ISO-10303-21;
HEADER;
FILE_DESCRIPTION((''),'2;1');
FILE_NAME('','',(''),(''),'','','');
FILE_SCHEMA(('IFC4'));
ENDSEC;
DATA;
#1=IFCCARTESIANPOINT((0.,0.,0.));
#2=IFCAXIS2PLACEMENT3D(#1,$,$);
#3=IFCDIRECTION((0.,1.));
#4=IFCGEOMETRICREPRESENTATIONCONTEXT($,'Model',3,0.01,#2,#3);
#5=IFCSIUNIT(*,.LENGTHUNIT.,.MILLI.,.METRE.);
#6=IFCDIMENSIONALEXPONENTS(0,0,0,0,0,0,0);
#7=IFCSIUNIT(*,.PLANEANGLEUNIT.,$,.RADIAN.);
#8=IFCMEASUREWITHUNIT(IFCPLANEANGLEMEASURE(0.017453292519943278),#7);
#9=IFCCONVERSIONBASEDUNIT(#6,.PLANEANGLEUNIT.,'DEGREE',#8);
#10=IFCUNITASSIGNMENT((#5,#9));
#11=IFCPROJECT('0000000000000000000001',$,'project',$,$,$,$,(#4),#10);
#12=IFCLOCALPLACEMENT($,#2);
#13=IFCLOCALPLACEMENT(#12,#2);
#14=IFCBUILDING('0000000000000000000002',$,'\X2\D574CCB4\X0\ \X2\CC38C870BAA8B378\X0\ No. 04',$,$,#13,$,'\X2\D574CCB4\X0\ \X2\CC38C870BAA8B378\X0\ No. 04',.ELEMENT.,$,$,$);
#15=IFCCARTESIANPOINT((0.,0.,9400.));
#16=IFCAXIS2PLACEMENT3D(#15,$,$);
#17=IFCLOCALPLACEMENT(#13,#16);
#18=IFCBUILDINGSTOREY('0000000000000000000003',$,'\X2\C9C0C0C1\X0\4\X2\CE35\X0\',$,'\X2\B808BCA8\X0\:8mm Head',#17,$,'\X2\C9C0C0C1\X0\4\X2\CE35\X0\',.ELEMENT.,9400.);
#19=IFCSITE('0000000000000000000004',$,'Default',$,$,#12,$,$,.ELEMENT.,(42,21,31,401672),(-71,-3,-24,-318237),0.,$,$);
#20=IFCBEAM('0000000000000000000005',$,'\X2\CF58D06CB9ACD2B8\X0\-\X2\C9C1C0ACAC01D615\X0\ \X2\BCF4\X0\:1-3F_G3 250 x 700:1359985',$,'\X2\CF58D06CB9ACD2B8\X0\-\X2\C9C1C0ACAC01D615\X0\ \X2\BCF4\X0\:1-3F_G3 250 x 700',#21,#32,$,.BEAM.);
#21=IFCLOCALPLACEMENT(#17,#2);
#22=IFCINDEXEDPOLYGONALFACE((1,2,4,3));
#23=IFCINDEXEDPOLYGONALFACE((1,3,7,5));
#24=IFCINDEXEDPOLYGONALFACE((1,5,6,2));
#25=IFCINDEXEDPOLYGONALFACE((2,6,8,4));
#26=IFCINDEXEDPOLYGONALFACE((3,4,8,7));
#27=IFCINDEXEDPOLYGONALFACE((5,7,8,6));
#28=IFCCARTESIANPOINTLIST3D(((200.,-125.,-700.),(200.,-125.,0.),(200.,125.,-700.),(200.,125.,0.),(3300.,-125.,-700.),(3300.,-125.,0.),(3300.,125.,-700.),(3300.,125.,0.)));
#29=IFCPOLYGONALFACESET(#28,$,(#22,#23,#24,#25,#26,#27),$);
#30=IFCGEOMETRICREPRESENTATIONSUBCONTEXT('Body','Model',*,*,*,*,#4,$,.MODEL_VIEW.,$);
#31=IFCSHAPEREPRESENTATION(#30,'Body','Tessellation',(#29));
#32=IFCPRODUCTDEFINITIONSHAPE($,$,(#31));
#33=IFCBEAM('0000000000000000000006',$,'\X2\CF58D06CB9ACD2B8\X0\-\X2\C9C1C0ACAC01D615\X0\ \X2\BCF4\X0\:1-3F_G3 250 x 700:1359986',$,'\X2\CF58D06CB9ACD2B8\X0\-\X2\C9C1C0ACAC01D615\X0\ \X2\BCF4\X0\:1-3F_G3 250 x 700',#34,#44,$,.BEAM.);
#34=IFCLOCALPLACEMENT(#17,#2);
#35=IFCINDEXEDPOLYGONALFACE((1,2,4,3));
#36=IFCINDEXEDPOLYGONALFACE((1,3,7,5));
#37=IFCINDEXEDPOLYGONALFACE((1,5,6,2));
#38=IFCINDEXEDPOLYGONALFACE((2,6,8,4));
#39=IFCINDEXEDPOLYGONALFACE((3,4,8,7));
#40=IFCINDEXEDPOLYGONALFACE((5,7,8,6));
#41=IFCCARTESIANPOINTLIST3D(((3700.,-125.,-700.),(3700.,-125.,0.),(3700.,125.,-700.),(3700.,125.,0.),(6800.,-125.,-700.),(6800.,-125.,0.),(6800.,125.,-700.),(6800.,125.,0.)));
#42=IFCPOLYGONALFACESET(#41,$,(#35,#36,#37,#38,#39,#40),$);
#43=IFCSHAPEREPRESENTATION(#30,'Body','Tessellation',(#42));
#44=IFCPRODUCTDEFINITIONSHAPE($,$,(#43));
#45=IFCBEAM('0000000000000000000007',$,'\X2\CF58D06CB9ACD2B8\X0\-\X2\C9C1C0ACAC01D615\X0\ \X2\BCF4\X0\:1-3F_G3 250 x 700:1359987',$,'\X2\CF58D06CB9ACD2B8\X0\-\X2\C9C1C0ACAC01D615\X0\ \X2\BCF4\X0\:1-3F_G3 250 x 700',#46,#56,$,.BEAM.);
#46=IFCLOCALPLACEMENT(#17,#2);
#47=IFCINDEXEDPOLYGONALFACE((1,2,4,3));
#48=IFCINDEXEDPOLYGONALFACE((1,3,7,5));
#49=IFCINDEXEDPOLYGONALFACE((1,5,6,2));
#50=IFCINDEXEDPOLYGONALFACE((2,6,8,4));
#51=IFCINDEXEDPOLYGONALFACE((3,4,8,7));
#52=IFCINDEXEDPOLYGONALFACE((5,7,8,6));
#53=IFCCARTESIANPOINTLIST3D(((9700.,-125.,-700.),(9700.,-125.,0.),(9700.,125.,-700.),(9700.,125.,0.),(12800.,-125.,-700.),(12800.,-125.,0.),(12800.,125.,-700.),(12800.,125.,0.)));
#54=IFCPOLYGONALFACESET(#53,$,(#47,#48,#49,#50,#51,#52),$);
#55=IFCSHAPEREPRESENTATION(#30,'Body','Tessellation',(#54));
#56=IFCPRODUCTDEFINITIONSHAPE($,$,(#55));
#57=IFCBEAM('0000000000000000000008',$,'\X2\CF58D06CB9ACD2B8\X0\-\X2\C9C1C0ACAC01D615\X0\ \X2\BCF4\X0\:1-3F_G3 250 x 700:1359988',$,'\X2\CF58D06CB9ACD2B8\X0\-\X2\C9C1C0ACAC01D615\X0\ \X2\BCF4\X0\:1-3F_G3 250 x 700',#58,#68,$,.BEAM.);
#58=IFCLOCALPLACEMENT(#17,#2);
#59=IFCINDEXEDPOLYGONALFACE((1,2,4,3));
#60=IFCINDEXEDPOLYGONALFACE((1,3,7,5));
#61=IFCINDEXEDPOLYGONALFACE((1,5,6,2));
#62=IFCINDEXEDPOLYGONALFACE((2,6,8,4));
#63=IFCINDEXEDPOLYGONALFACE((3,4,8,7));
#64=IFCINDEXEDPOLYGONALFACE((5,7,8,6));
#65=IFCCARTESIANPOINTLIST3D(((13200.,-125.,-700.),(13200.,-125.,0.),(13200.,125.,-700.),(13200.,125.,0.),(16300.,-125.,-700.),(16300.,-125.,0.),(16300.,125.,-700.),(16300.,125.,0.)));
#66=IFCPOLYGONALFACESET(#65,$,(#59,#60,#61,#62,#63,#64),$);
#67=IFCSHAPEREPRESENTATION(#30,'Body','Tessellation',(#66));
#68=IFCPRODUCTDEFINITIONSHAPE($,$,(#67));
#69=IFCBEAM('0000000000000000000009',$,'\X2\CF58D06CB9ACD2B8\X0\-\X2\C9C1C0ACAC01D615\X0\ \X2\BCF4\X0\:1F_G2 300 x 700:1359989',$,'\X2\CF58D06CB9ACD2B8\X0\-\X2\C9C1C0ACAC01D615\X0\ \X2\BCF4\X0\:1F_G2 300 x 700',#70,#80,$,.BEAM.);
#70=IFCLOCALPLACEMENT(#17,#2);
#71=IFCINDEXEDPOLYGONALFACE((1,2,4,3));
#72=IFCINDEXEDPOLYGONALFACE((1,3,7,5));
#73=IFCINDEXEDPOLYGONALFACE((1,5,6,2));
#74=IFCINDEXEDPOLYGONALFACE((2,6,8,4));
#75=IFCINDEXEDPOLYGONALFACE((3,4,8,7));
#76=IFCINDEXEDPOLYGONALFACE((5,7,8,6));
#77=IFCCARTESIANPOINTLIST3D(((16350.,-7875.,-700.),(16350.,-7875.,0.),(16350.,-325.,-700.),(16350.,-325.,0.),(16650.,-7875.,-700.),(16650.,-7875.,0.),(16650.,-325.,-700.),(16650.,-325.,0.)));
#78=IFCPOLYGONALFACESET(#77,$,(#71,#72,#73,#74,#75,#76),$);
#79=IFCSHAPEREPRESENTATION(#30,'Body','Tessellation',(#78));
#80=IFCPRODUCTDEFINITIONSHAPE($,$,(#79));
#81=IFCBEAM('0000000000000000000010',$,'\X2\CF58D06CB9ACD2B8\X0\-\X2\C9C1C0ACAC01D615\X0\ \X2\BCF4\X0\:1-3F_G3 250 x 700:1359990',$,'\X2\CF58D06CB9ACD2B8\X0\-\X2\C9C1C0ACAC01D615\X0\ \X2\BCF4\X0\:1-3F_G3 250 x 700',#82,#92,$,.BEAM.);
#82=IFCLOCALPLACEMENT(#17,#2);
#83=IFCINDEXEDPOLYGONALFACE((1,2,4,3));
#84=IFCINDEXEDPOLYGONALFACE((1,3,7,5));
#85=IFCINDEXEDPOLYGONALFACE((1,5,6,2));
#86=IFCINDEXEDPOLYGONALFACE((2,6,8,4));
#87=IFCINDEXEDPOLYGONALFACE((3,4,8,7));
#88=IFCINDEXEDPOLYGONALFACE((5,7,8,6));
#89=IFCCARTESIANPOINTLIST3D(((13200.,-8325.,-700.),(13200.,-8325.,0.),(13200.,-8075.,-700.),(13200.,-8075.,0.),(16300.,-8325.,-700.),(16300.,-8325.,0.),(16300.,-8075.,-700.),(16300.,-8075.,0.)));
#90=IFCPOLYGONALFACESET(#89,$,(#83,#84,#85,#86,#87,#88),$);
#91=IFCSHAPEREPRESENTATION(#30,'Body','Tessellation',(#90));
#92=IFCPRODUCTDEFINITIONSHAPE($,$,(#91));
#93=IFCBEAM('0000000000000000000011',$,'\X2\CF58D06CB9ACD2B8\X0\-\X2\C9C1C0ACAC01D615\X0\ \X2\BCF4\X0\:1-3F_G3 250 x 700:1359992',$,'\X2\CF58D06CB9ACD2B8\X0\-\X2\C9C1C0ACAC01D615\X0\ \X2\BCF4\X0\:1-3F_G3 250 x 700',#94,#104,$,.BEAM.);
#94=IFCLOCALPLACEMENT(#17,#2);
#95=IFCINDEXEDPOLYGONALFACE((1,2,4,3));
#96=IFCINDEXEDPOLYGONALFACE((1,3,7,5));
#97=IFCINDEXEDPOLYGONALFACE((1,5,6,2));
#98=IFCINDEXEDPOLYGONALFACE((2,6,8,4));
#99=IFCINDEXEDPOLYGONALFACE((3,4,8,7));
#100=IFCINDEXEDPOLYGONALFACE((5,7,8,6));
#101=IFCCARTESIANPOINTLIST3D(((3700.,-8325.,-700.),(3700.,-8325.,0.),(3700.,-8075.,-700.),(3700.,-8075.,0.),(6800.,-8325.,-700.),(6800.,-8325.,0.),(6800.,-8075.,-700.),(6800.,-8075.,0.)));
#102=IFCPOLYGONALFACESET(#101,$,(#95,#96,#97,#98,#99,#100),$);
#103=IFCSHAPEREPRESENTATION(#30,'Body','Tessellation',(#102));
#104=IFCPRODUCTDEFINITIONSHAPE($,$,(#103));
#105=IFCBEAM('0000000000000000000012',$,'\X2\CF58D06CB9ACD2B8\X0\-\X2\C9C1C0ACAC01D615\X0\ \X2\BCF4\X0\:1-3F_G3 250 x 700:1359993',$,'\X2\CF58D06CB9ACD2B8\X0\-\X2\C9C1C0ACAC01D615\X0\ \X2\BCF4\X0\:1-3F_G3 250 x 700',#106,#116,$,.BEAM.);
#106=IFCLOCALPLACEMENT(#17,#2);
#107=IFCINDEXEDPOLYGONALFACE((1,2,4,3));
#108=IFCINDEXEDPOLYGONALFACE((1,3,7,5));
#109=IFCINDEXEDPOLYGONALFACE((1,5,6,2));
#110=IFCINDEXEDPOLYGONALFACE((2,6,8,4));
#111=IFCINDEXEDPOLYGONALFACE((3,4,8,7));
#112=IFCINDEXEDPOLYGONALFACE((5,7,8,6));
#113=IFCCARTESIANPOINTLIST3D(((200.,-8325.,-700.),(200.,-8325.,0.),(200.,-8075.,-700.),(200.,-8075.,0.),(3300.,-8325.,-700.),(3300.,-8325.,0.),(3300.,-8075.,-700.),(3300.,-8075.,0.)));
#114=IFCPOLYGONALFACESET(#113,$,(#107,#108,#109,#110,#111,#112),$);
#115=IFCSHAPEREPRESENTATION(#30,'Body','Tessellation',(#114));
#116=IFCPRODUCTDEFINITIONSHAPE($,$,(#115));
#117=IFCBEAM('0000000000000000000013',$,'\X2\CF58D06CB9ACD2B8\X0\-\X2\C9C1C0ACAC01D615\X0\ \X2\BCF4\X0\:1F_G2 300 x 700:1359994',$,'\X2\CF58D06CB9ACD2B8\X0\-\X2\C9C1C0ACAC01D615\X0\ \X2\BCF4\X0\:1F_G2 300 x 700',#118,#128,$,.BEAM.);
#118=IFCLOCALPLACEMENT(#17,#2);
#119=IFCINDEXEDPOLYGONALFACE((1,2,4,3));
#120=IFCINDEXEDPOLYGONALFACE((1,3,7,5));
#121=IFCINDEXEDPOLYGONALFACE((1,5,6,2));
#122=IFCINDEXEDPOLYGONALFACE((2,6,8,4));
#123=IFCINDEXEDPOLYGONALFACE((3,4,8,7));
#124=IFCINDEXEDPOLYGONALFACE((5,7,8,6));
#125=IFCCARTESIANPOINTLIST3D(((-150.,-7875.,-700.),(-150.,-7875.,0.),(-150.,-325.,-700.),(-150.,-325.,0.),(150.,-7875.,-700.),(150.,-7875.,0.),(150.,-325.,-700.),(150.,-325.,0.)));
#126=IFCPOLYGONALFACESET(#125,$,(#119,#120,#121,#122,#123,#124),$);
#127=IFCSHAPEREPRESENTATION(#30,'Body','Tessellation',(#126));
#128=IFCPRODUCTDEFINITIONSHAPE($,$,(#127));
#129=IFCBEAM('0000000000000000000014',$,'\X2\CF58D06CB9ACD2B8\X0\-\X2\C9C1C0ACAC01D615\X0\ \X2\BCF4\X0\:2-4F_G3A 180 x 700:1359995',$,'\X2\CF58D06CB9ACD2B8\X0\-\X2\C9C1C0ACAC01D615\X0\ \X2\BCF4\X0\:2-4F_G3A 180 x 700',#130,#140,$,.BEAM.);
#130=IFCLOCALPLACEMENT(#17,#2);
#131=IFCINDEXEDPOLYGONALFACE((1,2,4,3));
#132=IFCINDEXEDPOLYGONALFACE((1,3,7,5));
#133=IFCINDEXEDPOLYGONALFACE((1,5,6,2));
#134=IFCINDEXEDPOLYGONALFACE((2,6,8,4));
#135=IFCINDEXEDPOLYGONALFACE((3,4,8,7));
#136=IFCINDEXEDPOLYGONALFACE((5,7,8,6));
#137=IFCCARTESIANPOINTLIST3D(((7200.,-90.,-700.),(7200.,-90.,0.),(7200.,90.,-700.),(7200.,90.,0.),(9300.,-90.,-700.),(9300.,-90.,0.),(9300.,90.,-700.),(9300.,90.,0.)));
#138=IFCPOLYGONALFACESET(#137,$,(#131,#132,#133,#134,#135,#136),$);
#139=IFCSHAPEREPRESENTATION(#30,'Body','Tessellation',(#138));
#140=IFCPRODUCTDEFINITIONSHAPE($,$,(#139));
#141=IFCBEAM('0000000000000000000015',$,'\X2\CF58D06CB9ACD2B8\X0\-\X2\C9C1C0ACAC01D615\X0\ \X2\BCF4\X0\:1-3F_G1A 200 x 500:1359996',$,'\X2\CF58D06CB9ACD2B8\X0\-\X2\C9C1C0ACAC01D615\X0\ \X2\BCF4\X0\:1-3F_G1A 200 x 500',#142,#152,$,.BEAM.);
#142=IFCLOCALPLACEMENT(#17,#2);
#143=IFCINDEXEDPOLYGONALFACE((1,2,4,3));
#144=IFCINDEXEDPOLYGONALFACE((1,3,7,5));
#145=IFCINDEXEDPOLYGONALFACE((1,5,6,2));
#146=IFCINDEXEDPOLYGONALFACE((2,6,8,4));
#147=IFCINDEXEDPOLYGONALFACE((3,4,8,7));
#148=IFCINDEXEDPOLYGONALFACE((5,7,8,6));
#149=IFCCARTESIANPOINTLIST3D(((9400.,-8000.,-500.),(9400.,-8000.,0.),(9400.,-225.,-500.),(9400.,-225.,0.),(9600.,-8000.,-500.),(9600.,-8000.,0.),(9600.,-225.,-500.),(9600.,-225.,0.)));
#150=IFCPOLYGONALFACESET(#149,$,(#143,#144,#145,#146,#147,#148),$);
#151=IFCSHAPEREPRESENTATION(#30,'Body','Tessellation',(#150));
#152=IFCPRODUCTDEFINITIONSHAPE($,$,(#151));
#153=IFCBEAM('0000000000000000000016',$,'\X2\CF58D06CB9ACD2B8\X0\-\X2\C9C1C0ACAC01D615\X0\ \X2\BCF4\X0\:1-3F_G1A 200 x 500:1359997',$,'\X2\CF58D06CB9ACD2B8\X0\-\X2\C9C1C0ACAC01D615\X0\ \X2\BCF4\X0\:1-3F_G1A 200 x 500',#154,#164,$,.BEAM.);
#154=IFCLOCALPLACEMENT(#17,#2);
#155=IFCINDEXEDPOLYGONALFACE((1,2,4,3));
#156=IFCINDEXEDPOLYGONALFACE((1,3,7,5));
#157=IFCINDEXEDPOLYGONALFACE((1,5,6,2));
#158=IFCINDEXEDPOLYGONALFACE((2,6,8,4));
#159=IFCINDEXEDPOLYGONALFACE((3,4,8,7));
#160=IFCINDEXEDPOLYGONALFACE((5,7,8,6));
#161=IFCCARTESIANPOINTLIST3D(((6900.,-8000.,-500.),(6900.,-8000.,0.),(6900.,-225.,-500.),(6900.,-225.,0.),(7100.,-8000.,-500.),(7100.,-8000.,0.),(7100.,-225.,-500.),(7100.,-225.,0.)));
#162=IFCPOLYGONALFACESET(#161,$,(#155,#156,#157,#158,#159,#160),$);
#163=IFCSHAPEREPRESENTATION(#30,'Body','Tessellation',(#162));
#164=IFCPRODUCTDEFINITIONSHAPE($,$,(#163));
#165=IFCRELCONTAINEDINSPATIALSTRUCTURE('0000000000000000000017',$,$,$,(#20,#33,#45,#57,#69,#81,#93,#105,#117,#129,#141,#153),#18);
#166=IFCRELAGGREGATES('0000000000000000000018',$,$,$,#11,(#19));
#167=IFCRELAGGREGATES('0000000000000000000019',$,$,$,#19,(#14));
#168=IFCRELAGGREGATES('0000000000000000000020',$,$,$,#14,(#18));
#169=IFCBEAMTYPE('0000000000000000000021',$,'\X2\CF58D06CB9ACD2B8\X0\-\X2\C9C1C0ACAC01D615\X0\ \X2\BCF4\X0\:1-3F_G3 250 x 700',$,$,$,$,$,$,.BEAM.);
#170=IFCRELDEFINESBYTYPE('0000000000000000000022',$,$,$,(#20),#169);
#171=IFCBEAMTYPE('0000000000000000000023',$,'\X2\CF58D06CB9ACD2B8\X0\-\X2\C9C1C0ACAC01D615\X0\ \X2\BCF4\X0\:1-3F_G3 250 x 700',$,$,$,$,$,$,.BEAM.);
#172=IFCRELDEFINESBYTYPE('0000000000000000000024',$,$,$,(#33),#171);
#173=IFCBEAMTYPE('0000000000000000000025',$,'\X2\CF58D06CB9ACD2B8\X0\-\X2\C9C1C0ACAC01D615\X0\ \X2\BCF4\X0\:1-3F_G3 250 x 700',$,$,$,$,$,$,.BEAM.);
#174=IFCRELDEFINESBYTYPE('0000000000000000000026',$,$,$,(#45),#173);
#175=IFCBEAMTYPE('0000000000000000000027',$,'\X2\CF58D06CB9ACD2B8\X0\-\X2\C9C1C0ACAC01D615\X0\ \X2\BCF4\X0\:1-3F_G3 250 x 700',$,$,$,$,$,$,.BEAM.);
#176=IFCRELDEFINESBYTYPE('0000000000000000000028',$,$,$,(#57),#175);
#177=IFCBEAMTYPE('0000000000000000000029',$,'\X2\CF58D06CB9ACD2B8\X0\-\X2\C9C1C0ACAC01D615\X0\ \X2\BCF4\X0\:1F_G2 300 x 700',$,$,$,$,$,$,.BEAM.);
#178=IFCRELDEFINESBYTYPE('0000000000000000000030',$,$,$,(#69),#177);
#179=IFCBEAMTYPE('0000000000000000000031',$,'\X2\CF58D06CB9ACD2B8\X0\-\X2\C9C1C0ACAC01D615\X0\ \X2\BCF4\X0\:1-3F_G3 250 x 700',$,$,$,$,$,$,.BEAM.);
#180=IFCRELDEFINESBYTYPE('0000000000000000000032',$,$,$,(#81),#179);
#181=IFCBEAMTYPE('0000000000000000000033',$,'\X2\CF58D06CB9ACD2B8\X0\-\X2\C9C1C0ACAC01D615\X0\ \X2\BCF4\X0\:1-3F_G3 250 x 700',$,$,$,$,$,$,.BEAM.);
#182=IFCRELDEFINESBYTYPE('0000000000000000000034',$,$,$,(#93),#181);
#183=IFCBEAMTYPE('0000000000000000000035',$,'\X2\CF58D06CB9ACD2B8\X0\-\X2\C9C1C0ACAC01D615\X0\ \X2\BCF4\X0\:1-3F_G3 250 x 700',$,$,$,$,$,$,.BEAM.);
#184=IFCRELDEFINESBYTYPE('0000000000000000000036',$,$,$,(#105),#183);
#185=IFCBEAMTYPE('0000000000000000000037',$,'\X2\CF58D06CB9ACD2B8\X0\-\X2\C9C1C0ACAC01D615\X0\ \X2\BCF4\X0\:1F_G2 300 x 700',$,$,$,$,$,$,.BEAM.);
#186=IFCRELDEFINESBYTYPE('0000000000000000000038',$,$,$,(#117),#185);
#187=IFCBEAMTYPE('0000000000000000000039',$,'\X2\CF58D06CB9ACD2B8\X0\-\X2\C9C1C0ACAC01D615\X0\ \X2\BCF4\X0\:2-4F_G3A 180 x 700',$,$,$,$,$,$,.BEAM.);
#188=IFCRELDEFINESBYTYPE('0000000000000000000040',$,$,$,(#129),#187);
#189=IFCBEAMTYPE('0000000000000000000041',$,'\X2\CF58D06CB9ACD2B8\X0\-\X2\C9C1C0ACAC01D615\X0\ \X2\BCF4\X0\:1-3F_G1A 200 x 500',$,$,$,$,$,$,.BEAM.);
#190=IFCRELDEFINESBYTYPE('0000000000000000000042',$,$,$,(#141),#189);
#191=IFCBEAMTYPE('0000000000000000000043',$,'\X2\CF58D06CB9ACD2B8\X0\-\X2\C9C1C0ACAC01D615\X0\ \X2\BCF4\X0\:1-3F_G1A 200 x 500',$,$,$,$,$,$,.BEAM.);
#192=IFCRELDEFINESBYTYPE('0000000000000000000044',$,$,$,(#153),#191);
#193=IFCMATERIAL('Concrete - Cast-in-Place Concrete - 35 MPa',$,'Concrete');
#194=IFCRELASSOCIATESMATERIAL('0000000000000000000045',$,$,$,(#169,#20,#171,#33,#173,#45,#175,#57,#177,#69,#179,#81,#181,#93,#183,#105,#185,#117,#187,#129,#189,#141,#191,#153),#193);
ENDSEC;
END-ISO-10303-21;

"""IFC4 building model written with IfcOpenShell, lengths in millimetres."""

from ifc_helpers import new_model, entity, si_unit, converted_unit, direction, frame, origin, place, context, subcontext, project, spatial, indexed_curve, outline, extrude, source, transform, mapped, material, type_object, type_shapes, element, save


model = new_model("IFC4")

# Units and contexts
model_context = context("Model", 3, precision=0.01, world=origin(), true_north=direction((0.0, 1.0)))
body_context = subcontext(model_context, "Body", "Model", "MODEL_VIEW")
ifc_project = project(units=[si_unit("LENGTHUNIT", "METRE", prefix="MILLI"), converted_unit("PLANEANGLEUNIT", "DEGREE", entity("IfcPlaneAngleMeasure", 0.017453292519943278), si_unit("PLANEANGLEUNIT", "RADIAN"), dimensions=[0, 0, 0, 0, 0, 0, 0])], contexts=[model_context])

# Site, building, storey
site_placement = place(None, origin())
site = spatial("IfcSite", under=ifc_project, at=site_placement, Name="Default", CompositionType="ELEMENT", RefLatitude=(42, 21, 31, 401672), RefLongitude=(-71, -3, -24, -318237), RefElevation=0.0)
building_placement = place(site_placement, origin())
building = spatial("IfcBuilding", under=site, at=building_placement, Name="해체 참조모델 No. 04", LongName="해체 참조모델 No. 04", CompositionType="ELEMENT")
storey_placement = place(building_placement, frame((0.0, 0.0, 9400.0)))
storey = spatial("IfcBuildingStorey", under=building, at=storey_placement, Name="지상4층", ObjectType="레벨:8mm Head", LongName="지상4층", CompositionType="ELEMENT", Elevation=9400.0)

# Beams
ifc_material_1 = material(Name="Concrete - Cast-in-Place Concrete - 35 MPa", Category="Concrete")
beam_type_1 = type_object("IfcBeamType", Name="콘크리트-직사각형 보:1-3F_G3 250 x 700", PredefinedType="BEAM", material=ifc_material_1)
shared_shape_1 = source(origin(), body_context, "Body", "SweptSolid", [
    extrude(outline(indexed_curve([(-350.0, -125.0), (350.0, -125.0), (350.0, 125.0), (-350.0, 125.0), (-350.0, -125.0)], self_intersect=False)), frame((200.0, 0.0, 9050.0), z_axis=(1.0, 0.0, 0.0), x_axis=(0.0, 0.0, -1.0)), (0.0, 0.0, 1.0), 3100.0),
])
type_shapes(beam_type_1, [shared_shape_1])
beam_1_placement = place(storey_placement, frame((0.0, 0.0, -9400.0)))
element("IfcBeam", 1, at=beam_1_placement, inside=storey, type_object=beam_type_1, material=ifc_material_1, Name="콘크리트-직사각형 보:1-3F_G3 250 x 700:1359985", ObjectType="콘크리트-직사각형 보:1-3F_G3 250 x 700", PredefinedType="BEAM", context=body_context, shape_type="MappedRepresentation", body=[
    mapped(shared_shape_1, transform((0.0, 0.0, 0.0), scale=1.0)),
])
beam_type_2 = type_object("IfcBeamType", Name="콘크리트-직사각형 보:1-3F_G3 250 x 700", PredefinedType="BEAM", material=ifc_material_1)
shared_shape_2 = source(origin(), body_context, "Body", "SweptSolid", [
    extrude(outline(indexed_curve([(-350.0, -125.0), (350.0, -125.0), (350.0, 125.0), (-350.0, 125.0), (-350.0, -125.0)], self_intersect=False)), frame((3700.0, 0.0, 9050.0), z_axis=(1.0, 0.0, 0.0), x_axis=(0.0, 0.0, -1.0)), (0.0, 0.0, 1.0), 3100.0),
])
type_shapes(beam_type_2, [shared_shape_2])
beam_2_placement = place(storey_placement, frame((0.0, 0.0, -9400.0)))
element("IfcBeam", 2, at=beam_2_placement, inside=storey, type_object=beam_type_2, material=ifc_material_1, Name="콘크리트-직사각형 보:1-3F_G3 250 x 700:1359986", ObjectType="콘크리트-직사각형 보:1-3F_G3 250 x 700", PredefinedType="BEAM", context=body_context, shape_type="MappedRepresentation", body=[
    mapped(shared_shape_2, transform((0.0, 0.0, 0.0), scale=1.0)),
])
beam_type_3 = type_object("IfcBeamType", Name="콘크리트-직사각형 보:1-3F_G3 250 x 700", PredefinedType="BEAM", material=ifc_material_1)
shared_shape_3 = source(origin(), body_context, "Body", "SweptSolid", [
    extrude(outline(indexed_curve([(-350.0, -125.0), (350.0, -125.0), (350.0, 125.0), (-350.0, 125.0), (-350.0, -125.0)], self_intersect=False)), frame((9700.0, 0.0, 9050.0), z_axis=(1.0, 0.0, 0.0), x_axis=(0.0, 0.0, -1.0)), (0.0, 0.0, 1.0), 3100.0),
])
type_shapes(beam_type_3, [shared_shape_3])
beam_3_placement = place(storey_placement, frame((0.0, 0.0, -9400.0)))
element("IfcBeam", 3, at=beam_3_placement, inside=storey, type_object=beam_type_3, material=ifc_material_1, Name="콘크리트-직사각형 보:1-3F_G3 250 x 700:1359987", ObjectType="콘크리트-직사각형 보:1-3F_G3 250 x 700", PredefinedType="BEAM", context=body_context, shape_type="MappedRepresentation", body=[
    mapped(shared_shape_3, transform((0.0, 0.0, 0.0), scale=1.0)),
])
beam_type_4 = type_object("IfcBeamType", Name="콘크리트-직사각형 보:1-3F_G3 250 x 700", PredefinedType="BEAM", material=ifc_material_1)
shared_shape_4 = source(origin(), body_context, "Body", "SweptSolid", [
    extrude(outline(indexed_curve([(-350.0, -125.0), (350.0, -125.0), (350.0, 125.0), (-350.0, 125.0), (-350.0, -125.0)], self_intersect=False)), frame((13200.0, 0.0, 9050.0), z_axis=(1.0, 0.0, 0.0), x_axis=(0.0, 0.0, -1.0)), (0.0, 0.0, 1.0), 3100.0),
])
type_shapes(beam_type_4, [shared_shape_4])
beam_4_placement = place(storey_placement, frame((0.0, 0.0, -9400.0)))
element("IfcBeam", 4, at=beam_4_placement, inside=storey, type_object=beam_type_4, material=ifc_material_1, Name="콘크리트-직사각형 보:1-3F_G3 250 x 700:1359988", ObjectType="콘크리트-직사각형 보:1-3F_G3 250 x 700", PredefinedType="BEAM", context=body_context, shape_type="MappedRepresentation", body=[
    mapped(shared_shape_4, transform((0.0, 0.0, 0.0), scale=1.0)),
])
beam_type_5 = type_object("IfcBeamType", Name="콘크리트-직사각형 보:1F_G2 300 x 700", PredefinedType="BEAM", material=ifc_material_1)
shared_shape_5 = source(origin(), body_context, "Body", "SweptSolid", [
    extrude(outline(indexed_curve([(-150.0, -350.0), (150.0, -350.0), (150.0, 350.0), (-150.0, 350.0), (-150.0, -350.0)], self_intersect=False)), frame((16500.0, -325.0, 9050.0), z_axis=(0.0, -1.0, 0.0), x_axis=(-1.0, 0.0, 0.0)), (0.0, 0.0, 1.0), 7550.0),
])
type_shapes(beam_type_5, [shared_shape_5])
beam_5_placement = place(storey_placement, frame((0.0, 0.0, -9400.0)))
element("IfcBeam", 5, at=beam_5_placement, inside=storey, type_object=beam_type_5, material=ifc_material_1, Name="콘크리트-직사각형 보:1F_G2 300 x 700:1359989", ObjectType="콘크리트-직사각형 보:1F_G2 300 x 700", PredefinedType="BEAM", context=body_context, shape_type="MappedRepresentation", body=[
    mapped(shared_shape_5, transform((0.0, 0.0, 0.0), scale=1.0)),
])
beam_type_6 = type_object("IfcBeamType", Name="콘크리트-직사각형 보:1-3F_G3 250 x 700", PredefinedType="BEAM", material=ifc_material_1)
shared_shape_6 = source(origin(), body_context, "Body", "SweptSolid", [
    extrude(outline(indexed_curve([(-350.0, -125.0), (350.0, -125.0), (350.0, 125.0), (-350.0, 125.0), (-350.0, -125.0)], self_intersect=False)), frame((16300.0, -8200.0, 9050.0), z_axis=(-1.0, 0.0, 0.0), x_axis=(0.0, 0.0, -1.0)), (0.0, 0.0, 1.0), 3100.0),
])
type_shapes(beam_type_6, [shared_shape_6])
beam_6_placement = place(storey_placement, frame((0.0, 0.0, -9400.0)))
element("IfcBeam", 6, at=beam_6_placement, inside=storey, type_object=beam_type_6, material=ifc_material_1, Name="콘크리트-직사각형 보:1-3F_G3 250 x 700:1359990", ObjectType="콘크리트-직사각형 보:1-3F_G3 250 x 700", PredefinedType="BEAM", context=body_context, shape_type="MappedRepresentation", body=[
    mapped(shared_shape_6, transform((0.0, 0.0, 0.0), scale=1.0)),
])
beam_type_7 = type_object("IfcBeamType", Name="콘크리트-직사각형 보:1-3F_G3 250 x 700", PredefinedType="BEAM", material=ifc_material_1)
shared_shape_7 = source(origin(), body_context, "Body", "SweptSolid", [
    extrude(outline(indexed_curve([(-350.0, -125.0), (350.0, -125.0), (350.0, 125.0), (-350.0, 125.0), (-350.0, -125.0)], self_intersect=False)), frame((6800.0, -8200.0, 9050.0), z_axis=(-1.0, 0.0, 0.0), x_axis=(0.0, 0.0, -1.0)), (0.0, 0.0, 1.0), 3100.0),
])
type_shapes(beam_type_7, [shared_shape_7])
beam_7_placement = place(storey_placement, frame((0.0, 0.0, -9400.0)))
element("IfcBeam", 7, at=beam_7_placement, inside=storey, type_object=beam_type_7, material=ifc_material_1, Name="콘크리트-직사각형 보:1-3F_G3 250 x 700:1359992", ObjectType="콘크리트-직사각형 보:1-3F_G3 250 x 700", PredefinedType="BEAM", context=body_context, shape_type="MappedRepresentation", body=[
    mapped(shared_shape_7, transform((0.0, 0.0, 0.0), scale=1.0)),
])
beam_type_8 = type_object("IfcBeamType", Name="콘크리트-직사각형 보:1-3F_G3 250 x 700", PredefinedType="BEAM", material=ifc_material_1)
shared_shape_8 = source(origin(), body_context, "Body", "SweptSolid", [
    extrude(outline(indexed_curve([(-350.0, -125.0), (350.0, -125.0), (350.0, 125.0), (-350.0, 125.0), (-350.0, -125.0)], self_intersect=False)), frame((3300.0, -8200.0, 9050.0), z_axis=(-1.0, 0.0, 0.0), x_axis=(0.0, 0.0, -1.0)), (0.0, 0.0, 1.0), 3100.0),
])
type_shapes(beam_type_8, [shared_shape_8])
beam_8_placement = place(storey_placement, frame((0.0, 0.0, -9400.0)))
element("IfcBeam", 8, at=beam_8_placement, inside=storey, type_object=beam_type_8, material=ifc_material_1, Name="콘크리트-직사각형 보:1-3F_G3 250 x 700:1359993", ObjectType="콘크리트-직사각형 보:1-3F_G3 250 x 700", PredefinedType="BEAM", context=body_context, shape_type="MappedRepresentation", body=[
    mapped(shared_shape_8, transform((0.0, 0.0, 0.0), scale=1.0)),
])
beam_type_9 = type_object("IfcBeamType", Name="콘크리트-직사각형 보:1F_G2 300 x 700", PredefinedType="BEAM", material=ifc_material_1)
shared_shape_9 = source(origin(), body_context, "Body", "SweptSolid", [
    extrude(outline(indexed_curve([(-150.0, -350.0), (150.0, -350.0), (150.0, 350.0), (-150.0, 350.0), (-150.0, -350.0)], self_intersect=False)), frame((0.0, -7875.0, 9050.0), z_axis=(0.0, 1.0, 0.0), x_axis=(-1.0, 0.0, 0.0)), (0.0, 0.0, 1.0), 7550.0),
])
type_shapes(beam_type_9, [shared_shape_9])
beam_9_placement = place(storey_placement, frame((0.0, 0.0, -9400.0)))
element("IfcBeam", 9, at=beam_9_placement, inside=storey, type_object=beam_type_9, material=ifc_material_1, Name="콘크리트-직사각형 보:1F_G2 300 x 700:1359994", ObjectType="콘크리트-직사각형 보:1F_G2 300 x 700", PredefinedType="BEAM", context=body_context, shape_type="MappedRepresentation", body=[
    mapped(shared_shape_9, transform((0.0, 0.0, 0.0), scale=1.0)),
])
beam_type_10 = type_object("IfcBeamType", Name="콘크리트-직사각형 보:2-4F_G3A 180 x 700", PredefinedType="BEAM", material=ifc_material_1)
shared_shape_10 = source(origin(), body_context, "Body", "SweptSolid", [
    extrude(outline(indexed_curve([(-350.0, -90.0), (350.0, -90.0), (350.0, 90.0), (-350.0, 90.0), (-350.0, -90.0)], self_intersect=False)), frame((7200.0, 0.0, 9050.0), z_axis=(1.0, 0.0, 0.0), x_axis=(0.0, 0.0, -1.0)), (0.0, 0.0, 1.0), 2100.0),
])
type_shapes(beam_type_10, [shared_shape_10])
beam_10_placement = place(storey_placement, frame((0.0, 0.0, -9400.0)))
element("IfcBeam", 10, at=beam_10_placement, inside=storey, type_object=beam_type_10, material=ifc_material_1, Name="콘크리트-직사각형 보:2-4F_G3A 180 x 700:1359995", ObjectType="콘크리트-직사각형 보:2-4F_G3A 180 x 700", PredefinedType="BEAM", context=body_context, shape_type="MappedRepresentation", body=[
    mapped(shared_shape_10, transform((0.0, 0.0, 0.0), scale=1.0)),
])
beam_type_11 = type_object("IfcBeamType", Name="콘크리트-직사각형 보:1-3F_G1A 200 x 500", PredefinedType="BEAM", material=ifc_material_1)
shared_shape_11 = source(origin(), body_context, "Body", "SweptSolid", [
    extrude(outline(indexed_curve([(-100.0, -250.0), (100.0, -250.0), (100.0, 250.0), (-100.0, 250.0), (-100.0, -250.0)], self_intersect=False)), frame((9500.0, -225.0, 9150.0), z_axis=(0.0, -1.0, 0.0), x_axis=(-1.0, 0.0, 0.0)), (0.0, 0.0, 1.0), 7775.0),
])
type_shapes(beam_type_11, [shared_shape_11])
beam_11_placement = place(storey_placement, frame((0.0, 0.0, -9400.0)))
element("IfcBeam", 11, at=beam_11_placement, inside=storey, type_object=beam_type_11, material=ifc_material_1, Name="콘크리트-직사각형 보:1-3F_G1A 200 x 500:1359996", ObjectType="콘크리트-직사각형 보:1-3F_G1A 200 x 500", PredefinedType="BEAM", context=body_context, shape_type="MappedRepresentation", body=[
    mapped(shared_shape_11, transform((0.0, 0.0, 0.0), scale=1.0)),
])
beam_type_12 = type_object("IfcBeamType", Name="콘크리트-직사각형 보:1-3F_G1A 200 x 500", PredefinedType="BEAM", material=ifc_material_1)
shared_shape_12 = source(origin(), body_context, "Body", "SweptSolid", [
    extrude(outline(indexed_curve([(-100.0, -250.0), (100.0, -250.0), (100.0, 250.0), (-100.0, 250.0), (-100.0, -250.0)], self_intersect=False)), frame((7000.0, -225.0, 9150.0), z_axis=(0.0, -1.0, 0.0), x_axis=(-1.0, 0.0, 0.0)), (0.0, 0.0, 1.0), 7775.0),
])
type_shapes(beam_type_12, [shared_shape_12])
beam_12_placement = place(storey_placement, frame((0.0, 0.0, -9400.0)))
element("IfcBeam", 12, at=beam_12_placement, inside=storey, type_object=beam_type_12, material=ifc_material_1, Name="콘크리트-직사각형 보:1-3F_G1A 200 x 500:1359997", ObjectType="콘크리트-직사각형 보:1-3F_G1A 200 x 500", PredefinedType="BEAM", context=body_context, shape_type="MappedRepresentation", body=[
    mapped(shared_shape_12, transform((0.0, 0.0, 0.0), scale=1.0)),
])

save(model, "model.ifc")
